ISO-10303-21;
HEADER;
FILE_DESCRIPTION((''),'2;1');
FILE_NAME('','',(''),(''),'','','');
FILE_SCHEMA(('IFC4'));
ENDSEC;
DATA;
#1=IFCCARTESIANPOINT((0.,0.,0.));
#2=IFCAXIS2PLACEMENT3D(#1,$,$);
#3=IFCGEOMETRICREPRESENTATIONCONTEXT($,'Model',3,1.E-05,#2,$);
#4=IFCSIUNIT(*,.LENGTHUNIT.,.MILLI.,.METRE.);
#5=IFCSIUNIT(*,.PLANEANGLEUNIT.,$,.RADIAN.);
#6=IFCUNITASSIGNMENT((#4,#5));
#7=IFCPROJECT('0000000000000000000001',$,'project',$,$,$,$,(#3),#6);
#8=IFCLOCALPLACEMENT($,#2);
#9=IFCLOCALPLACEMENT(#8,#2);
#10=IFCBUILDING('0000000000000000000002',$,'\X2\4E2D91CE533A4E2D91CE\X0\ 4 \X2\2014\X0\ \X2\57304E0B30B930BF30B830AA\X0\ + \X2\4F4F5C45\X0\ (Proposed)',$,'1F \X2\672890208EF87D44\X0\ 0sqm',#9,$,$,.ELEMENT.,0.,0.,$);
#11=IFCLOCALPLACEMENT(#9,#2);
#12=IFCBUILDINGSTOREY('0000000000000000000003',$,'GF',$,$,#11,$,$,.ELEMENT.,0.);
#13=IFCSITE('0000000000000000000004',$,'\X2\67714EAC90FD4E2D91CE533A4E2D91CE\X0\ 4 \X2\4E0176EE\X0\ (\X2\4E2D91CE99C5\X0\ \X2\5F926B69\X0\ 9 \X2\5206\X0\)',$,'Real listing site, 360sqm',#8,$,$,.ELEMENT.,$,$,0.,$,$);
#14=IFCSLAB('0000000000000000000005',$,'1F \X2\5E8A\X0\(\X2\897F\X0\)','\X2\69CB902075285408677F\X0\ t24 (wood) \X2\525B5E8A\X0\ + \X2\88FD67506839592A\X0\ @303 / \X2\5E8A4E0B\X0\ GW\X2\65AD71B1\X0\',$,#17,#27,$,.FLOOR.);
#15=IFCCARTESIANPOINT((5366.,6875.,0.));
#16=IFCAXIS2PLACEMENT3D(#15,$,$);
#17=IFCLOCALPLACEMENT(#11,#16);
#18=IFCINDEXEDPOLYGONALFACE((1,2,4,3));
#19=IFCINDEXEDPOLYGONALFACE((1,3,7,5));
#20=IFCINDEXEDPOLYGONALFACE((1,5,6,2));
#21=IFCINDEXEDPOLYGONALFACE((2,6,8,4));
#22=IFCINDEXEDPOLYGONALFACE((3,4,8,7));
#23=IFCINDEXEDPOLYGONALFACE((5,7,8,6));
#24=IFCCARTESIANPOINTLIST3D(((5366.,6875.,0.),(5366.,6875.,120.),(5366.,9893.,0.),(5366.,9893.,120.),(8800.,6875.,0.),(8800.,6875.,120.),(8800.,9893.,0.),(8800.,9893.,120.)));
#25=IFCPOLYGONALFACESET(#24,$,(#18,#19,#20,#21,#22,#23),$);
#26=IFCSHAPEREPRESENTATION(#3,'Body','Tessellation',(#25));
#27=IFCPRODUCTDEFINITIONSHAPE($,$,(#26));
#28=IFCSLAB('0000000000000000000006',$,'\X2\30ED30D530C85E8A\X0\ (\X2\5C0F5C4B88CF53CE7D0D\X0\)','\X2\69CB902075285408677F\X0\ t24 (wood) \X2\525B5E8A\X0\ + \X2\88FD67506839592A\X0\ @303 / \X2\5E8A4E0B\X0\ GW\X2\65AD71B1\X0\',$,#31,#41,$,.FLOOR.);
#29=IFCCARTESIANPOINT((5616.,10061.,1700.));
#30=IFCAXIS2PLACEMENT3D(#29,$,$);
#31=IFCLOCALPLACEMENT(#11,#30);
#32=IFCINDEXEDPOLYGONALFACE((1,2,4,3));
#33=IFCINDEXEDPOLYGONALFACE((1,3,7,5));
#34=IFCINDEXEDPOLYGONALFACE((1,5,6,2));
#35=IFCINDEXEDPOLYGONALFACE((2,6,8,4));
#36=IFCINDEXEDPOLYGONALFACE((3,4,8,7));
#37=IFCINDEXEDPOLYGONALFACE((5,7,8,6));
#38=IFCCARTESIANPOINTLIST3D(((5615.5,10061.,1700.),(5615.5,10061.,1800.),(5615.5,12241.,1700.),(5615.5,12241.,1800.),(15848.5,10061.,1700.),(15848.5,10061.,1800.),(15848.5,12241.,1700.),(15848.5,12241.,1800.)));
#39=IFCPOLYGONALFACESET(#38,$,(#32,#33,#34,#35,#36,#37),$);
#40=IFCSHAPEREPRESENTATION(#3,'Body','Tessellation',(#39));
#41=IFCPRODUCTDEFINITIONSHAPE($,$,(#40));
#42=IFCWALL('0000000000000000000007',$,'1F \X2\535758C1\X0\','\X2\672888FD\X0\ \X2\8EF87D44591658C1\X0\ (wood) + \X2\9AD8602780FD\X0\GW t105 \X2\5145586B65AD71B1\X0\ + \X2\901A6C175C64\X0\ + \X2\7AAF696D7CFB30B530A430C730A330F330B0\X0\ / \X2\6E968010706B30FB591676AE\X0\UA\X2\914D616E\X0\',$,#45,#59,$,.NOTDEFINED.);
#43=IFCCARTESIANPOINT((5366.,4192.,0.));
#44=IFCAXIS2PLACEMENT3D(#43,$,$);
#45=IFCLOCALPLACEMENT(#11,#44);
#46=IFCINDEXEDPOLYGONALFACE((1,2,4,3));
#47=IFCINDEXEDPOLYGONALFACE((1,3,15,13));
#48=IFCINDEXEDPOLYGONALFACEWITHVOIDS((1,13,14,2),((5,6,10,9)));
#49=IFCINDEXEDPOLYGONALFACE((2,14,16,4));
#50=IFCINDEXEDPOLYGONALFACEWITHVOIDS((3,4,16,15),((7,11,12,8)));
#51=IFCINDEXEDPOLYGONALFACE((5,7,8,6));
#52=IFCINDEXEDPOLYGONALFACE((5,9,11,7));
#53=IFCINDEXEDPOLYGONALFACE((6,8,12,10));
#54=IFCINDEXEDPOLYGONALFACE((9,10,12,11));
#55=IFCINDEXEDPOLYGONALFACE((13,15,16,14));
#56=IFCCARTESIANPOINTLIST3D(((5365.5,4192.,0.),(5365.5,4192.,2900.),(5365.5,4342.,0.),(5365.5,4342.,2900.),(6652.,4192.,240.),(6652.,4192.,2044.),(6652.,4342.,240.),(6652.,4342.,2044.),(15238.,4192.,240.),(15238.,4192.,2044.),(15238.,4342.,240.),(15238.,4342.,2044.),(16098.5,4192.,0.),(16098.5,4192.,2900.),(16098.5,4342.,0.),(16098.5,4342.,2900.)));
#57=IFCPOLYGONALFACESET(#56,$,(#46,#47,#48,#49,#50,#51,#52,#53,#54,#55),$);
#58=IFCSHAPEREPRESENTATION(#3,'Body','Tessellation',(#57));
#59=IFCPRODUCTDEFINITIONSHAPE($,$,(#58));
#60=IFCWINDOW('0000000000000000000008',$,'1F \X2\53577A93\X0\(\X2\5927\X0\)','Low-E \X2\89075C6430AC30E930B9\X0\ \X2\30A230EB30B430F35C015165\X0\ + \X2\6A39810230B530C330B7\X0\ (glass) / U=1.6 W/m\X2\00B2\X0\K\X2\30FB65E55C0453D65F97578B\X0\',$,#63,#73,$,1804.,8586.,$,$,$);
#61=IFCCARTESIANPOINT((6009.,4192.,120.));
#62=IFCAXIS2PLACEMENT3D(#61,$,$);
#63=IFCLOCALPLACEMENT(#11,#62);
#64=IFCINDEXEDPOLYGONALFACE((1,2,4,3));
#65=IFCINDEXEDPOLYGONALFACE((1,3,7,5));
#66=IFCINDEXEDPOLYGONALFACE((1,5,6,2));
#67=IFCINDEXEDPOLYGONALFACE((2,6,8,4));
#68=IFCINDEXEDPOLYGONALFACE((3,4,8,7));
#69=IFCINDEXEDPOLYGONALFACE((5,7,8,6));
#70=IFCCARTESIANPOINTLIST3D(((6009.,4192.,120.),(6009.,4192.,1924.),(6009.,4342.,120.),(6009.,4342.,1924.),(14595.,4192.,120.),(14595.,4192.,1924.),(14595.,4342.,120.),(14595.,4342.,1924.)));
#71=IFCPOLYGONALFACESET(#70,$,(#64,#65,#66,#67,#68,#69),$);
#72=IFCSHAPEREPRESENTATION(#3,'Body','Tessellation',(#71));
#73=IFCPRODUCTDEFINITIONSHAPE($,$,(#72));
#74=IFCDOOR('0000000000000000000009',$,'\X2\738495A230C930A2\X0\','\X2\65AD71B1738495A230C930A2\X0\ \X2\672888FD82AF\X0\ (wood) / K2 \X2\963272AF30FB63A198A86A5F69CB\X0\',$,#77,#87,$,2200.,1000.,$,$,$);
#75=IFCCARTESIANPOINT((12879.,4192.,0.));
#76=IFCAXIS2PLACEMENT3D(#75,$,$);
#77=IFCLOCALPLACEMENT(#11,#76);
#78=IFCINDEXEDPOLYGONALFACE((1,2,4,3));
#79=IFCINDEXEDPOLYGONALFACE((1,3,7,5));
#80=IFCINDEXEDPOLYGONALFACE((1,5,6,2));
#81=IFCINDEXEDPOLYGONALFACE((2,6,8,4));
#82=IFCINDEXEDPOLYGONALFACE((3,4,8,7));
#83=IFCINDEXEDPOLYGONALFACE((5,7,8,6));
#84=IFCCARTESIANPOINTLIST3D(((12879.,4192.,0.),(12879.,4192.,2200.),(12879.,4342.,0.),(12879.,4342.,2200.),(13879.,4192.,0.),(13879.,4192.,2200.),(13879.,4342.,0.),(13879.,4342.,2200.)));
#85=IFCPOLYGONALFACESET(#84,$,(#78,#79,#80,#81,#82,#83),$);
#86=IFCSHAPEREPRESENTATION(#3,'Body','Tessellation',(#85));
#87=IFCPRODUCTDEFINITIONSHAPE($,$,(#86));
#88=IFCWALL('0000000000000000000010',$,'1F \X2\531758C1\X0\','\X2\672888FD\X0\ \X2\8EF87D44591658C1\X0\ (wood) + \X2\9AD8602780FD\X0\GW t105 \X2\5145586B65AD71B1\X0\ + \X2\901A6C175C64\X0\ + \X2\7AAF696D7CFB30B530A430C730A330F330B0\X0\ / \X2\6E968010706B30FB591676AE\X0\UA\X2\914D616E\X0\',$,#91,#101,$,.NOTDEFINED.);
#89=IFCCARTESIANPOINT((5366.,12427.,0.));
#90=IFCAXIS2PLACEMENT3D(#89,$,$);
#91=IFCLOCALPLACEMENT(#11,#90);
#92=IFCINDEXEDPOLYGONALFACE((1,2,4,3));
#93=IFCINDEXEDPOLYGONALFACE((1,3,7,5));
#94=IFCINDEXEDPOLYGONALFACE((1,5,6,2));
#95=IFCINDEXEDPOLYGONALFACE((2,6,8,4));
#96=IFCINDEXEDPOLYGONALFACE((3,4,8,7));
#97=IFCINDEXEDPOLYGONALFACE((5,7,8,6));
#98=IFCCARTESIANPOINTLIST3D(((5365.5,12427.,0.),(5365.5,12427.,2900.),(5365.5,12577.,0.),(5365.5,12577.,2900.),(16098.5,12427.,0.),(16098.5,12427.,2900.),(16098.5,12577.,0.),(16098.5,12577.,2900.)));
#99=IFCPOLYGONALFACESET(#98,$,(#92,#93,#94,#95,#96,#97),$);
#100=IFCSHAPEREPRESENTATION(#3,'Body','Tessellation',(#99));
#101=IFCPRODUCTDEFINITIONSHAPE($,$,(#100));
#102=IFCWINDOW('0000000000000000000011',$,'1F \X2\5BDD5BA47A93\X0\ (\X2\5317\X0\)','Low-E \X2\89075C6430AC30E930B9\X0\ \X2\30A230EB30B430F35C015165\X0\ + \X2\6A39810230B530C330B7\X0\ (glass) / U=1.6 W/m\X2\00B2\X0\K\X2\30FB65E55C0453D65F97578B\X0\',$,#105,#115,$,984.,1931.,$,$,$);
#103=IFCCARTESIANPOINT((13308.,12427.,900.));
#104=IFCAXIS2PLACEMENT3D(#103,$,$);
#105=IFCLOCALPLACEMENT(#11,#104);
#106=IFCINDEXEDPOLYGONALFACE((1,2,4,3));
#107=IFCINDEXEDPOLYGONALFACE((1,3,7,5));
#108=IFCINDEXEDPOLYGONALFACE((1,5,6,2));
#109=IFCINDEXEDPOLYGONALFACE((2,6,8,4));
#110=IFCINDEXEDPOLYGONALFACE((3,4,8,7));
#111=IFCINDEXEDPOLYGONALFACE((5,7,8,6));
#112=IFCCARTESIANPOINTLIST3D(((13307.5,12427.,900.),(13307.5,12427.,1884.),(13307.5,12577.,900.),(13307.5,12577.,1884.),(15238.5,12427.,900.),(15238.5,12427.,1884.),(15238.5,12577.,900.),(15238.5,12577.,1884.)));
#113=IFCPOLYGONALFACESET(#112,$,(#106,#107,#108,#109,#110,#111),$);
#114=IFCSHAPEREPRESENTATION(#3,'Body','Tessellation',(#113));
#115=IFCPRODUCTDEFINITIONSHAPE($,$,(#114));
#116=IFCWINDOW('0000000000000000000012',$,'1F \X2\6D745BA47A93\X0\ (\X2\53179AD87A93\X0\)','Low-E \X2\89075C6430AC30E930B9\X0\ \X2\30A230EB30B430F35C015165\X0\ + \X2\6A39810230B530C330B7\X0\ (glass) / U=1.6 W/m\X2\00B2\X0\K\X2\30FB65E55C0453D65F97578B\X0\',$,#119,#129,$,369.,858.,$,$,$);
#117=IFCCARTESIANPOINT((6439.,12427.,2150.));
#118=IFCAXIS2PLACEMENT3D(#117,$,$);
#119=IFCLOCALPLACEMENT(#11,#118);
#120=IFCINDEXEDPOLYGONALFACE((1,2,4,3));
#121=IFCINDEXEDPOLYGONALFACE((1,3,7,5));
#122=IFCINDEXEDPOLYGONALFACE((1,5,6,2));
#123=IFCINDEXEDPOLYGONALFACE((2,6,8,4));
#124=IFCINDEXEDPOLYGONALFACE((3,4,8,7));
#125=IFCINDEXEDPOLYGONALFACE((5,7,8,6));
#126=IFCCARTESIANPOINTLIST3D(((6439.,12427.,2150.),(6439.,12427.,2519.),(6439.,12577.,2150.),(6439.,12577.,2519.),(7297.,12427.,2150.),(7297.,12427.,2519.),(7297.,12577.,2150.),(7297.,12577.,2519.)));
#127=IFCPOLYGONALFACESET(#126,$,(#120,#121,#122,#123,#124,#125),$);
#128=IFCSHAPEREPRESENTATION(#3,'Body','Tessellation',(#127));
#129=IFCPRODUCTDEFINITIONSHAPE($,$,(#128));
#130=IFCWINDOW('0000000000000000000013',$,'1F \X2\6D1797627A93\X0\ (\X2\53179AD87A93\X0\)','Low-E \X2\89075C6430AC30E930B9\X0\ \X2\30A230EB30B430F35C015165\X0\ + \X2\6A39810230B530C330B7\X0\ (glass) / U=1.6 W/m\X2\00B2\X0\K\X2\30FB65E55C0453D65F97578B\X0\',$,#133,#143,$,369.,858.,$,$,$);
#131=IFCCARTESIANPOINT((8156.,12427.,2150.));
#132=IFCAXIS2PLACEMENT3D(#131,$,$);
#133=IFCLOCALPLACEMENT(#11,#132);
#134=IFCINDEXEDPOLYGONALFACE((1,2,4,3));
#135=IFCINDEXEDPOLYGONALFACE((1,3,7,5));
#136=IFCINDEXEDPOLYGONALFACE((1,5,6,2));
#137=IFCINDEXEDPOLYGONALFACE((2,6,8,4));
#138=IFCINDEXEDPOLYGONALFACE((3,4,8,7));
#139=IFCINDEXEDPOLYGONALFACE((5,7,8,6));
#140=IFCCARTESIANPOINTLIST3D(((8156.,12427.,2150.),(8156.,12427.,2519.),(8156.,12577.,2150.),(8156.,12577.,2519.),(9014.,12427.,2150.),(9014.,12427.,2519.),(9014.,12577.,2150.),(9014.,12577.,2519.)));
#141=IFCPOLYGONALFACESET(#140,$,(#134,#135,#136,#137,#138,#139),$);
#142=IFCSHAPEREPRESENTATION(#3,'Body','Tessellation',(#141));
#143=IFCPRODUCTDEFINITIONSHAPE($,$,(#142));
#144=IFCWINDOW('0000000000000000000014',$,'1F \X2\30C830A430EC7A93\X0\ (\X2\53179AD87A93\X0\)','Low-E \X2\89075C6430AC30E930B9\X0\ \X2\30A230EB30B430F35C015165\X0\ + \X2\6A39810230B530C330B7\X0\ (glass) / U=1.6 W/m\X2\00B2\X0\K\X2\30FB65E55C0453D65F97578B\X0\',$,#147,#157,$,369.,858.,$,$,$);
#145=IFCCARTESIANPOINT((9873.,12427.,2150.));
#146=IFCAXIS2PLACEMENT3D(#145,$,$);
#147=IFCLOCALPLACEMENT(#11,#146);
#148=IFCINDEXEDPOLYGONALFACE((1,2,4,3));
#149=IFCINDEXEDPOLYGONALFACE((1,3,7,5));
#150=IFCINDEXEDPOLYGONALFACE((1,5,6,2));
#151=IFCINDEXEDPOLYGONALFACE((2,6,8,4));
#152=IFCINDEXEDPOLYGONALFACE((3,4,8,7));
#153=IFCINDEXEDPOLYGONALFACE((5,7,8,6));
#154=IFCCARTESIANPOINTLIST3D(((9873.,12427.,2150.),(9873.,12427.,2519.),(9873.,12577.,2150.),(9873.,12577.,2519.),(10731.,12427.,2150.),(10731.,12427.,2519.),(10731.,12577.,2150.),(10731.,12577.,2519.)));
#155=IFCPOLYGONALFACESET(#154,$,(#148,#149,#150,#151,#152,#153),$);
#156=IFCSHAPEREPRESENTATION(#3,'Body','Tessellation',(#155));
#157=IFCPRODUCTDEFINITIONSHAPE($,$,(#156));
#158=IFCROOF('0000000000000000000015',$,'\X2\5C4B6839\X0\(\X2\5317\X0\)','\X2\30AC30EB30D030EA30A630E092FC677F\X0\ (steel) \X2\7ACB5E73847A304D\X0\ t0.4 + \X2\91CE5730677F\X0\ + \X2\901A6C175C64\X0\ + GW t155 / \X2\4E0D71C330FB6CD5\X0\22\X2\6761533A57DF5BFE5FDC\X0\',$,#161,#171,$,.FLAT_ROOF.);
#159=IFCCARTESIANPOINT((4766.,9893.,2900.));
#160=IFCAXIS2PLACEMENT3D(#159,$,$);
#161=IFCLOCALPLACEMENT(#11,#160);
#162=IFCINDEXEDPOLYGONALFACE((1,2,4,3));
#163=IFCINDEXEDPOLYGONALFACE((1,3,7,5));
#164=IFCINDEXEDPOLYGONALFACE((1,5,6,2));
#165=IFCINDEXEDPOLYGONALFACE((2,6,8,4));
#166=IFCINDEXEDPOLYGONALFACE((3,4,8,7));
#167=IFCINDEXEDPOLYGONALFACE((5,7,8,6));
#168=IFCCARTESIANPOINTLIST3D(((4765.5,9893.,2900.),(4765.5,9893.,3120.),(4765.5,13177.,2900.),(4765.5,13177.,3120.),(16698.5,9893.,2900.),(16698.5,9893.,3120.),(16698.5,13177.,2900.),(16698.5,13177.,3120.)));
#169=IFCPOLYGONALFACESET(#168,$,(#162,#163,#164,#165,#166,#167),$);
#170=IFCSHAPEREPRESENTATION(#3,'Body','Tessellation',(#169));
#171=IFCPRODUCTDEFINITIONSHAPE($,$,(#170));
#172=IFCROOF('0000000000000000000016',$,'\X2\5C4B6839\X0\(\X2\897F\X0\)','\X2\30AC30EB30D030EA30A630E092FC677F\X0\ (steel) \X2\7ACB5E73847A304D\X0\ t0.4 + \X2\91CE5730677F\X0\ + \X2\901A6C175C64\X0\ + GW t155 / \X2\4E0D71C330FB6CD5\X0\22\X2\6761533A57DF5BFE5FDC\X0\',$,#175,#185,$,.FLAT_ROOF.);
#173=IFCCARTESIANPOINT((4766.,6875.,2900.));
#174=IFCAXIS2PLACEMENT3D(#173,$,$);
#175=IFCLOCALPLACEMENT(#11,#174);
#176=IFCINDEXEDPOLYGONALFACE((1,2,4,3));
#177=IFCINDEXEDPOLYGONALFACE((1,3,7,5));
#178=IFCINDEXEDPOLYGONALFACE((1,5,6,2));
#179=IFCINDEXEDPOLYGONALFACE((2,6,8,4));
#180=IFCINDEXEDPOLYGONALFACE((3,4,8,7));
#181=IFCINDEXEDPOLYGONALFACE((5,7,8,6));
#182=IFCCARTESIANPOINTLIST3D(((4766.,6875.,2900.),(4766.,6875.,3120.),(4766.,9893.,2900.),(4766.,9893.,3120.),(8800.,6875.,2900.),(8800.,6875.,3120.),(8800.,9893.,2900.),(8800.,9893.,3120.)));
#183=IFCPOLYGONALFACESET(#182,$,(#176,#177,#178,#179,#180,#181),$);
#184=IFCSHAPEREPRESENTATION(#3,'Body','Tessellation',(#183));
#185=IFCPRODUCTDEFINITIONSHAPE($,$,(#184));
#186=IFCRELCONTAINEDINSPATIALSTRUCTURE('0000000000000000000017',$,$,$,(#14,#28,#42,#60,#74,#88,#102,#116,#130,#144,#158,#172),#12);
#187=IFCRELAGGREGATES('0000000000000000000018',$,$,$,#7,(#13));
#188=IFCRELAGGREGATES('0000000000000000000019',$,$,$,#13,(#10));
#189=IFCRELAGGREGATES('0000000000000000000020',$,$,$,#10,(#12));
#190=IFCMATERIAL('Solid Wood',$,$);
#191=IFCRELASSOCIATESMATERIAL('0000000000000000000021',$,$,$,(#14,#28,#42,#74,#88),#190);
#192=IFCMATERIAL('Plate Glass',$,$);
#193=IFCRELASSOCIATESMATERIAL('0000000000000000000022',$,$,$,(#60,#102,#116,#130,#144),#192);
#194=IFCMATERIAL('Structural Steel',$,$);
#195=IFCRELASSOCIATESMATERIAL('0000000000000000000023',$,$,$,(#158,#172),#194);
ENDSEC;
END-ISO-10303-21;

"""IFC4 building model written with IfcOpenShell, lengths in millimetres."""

from ifc_helpers import new_model, si_unit, frame, frame_2d, origin, place, context, project, spatial, rectangle, extrude, material, element, fill, save


model = new_model("IFC4")

# Units and contexts
model_context = context("Model", 3, precision=1e-05, world=origin())
ifc_project = project(units=[si_unit("LENGTHUNIT", "METRE", prefix="MILLI"), si_unit("PLANEANGLEUNIT", "RADIAN")], contexts=[model_context])

# Site, building, storey
site_placement = place(None, origin())
site = spatial("IfcSite", under=ifc_project, at=site_placement, Name="東京都中野区中野 4 丁目 (中野駅 徒歩 9 分)", ObjectType="Real listing site, 360sqm", CompositionType="ELEMENT", RefElevation=0.0)
building_placement = place(site_placement, origin())
building = spatial("IfcBuilding", under=site, at=building_placement, Name="中野区中野 4 — 地下スタジオ + 住居 (Proposed)", ObjectType="1F 木造軸組 0sqm", CompositionType="ELEMENT", ElevationOfRefHeight=0.0, ElevationOfTerrain=0.0)
storey_placement = place(building_placement, origin())
storey = spatial("IfcBuildingStorey", under=building, at=storey_placement, Name="GF", CompositionType="ELEMENT", Elevation=0.0)

# Slabs
ifc_material_1 = material(Name="Solid Wood")
slab_1_placement = place(storey_placement, frame((5366.0, 6875.0, 0.0)))
element("IfcSlab", 1, at=slab_1_placement, inside=storey, material=ifc_material_1, Name="1F 床(西)", Description="構造用合板 t24 (wood) 剛床 + 製材根太 @303 / 床下 GW断熱", PredefinedType="FLOOR", context=model_context, shape_type="SweptSolid", body=[
    extrude(rectangle(XDim=3434.0, YDim=3018.0, at=frame_2d((1717.0, 1509.0))), frame((5366.0, 6875.0, 0.0)), (0.0, 0.0, 1.0), 120.0),
])
slab_2_placement = place(storey_placement, frame((5616.0, 10061.0, 1700.0)))
element("IfcSlab", 2, at=slab_2_placement, inside=storey, material=ifc_material_1, Name="ロフト床 (小屋裏収納)", Description="構造用合板 t24 (wood) 剛床 + 製材根太 @303 / 床下 GW断熱", PredefinedType="FLOOR", context=model_context, shape_type="SweptSolid", body=[
    extrude(rectangle(XDim=10233.0, YDim=2180.0, at=frame_2d((5116.0, 1090.0))), frame((5616.0, 10061.0, 1700.0)), (0.0, 0.0, 1.0), 100.0),
])

# Wall, openings, window, door
wall_1_placement = place(storey_placement, frame((5366.0, 4192.0, 0.0)))
wall_1 = element("IfcWall", 3, at=wall_1_placement, inside=storey, material=ifc_material_1, Name="1F 南壁", Description="木製 軸組外壁 (wood) + 高性能GW t105 充填断熱 + 通気層 + 窯業系サイディング / 準耐火・外皮UA配慮", PredefinedType="NOTDEFINED", context=model_context, shape_type="SweptSolid", body=[
    extrude(rectangle(XDim=10733.0, YDim=150.0, at=frame_2d((5366.0, 75.0))), frame((5366.0, 4192.0, 0.0)), (0.0, 0.0, 1.0), 2900.0),
])
opening_1_placement = place(storey_placement, frame((6009.0, 4192.0, 120.0)))
opening_1 = element("IfcOpeningElement", 4, at=opening_1_placement, cuts=wall_1, PredefinedType="NOTDEFINED", context=model_context, shape_type="SweptSolid", body=[
    extrude(rectangle(XDim=8586.0, YDim=150.0, at=frame_2d((4293.0, 75.0))), frame((6009.0, 4192.0, 120.0)), (0.0, 0.0, 1.0), 1804.0),
])
opening_2_placement = place(storey_placement, frame((12879.0, 4192.0, 0.0)))
opening_2 = element("IfcOpeningElement", 5, at=opening_2_placement, cuts=wall_1, PredefinedType="NOTDEFINED", context=model_context, shape_type="SweptSolid", body=[
    extrude(rectangle(XDim=1000.0, YDim=150.0, at=frame_2d((500.0, 75.0))), frame((12879.0, 4192.0, 0.0)), (0.0, 0.0, 1.0), 2200.0),
])
ifc_material_2 = material(Name="Plate Glass")
window_1_placement = place(storey_placement, frame((6009.0, 4192.0, 120.0)))
window_1 = element("IfcWindow", 6, at=window_1_placement, inside=storey, material=ifc_material_2, Name="1F 南窓(大)", Description="Low-E 複層ガラス アルゴン封入 + 樹脂サッシ (glass) / U=1.6 W/m²K・日射取得型", OverallHeight=1804.0, OverallWidth=8586.0, context=model_context, shape_type="SweptSolid", body=[
    extrude(rectangle(XDim=8586.0, YDim=150.0, at=frame_2d((4293.0, 75.0))), frame((6009.0, 4192.0, 120.0)), (0.0, 0.0, 1.0), 1804.0),
])
fill(opening_1, window_1)
door_1_placement = place(storey_placement, frame((12879.0, 4192.0, 0.0)))
door_1 = element("IfcDoor", 7, at=door_1_placement, inside=storey, material=ifc_material_1, Name="玄関ドア", Description="断熱玄関ドア 木製芯 (wood) / K2 防犯・採風機構", OverallHeight=2200.0, OverallWidth=1000.0, context=model_context, shape_type="SweptSolid", body=[
    extrude(rectangle(XDim=1000.0, YDim=150.0, at=frame_2d((500.0, 75.0))), frame((12879.0, 4192.0, 0.0)), (0.0, 0.0, 1.0), 2200.0),
])
fill(opening_2, door_1)

# Wall, openings, windows
wall_2_placement = place(storey_placement, frame((5366.0, 12427.0, 0.0)))
wall_2 = element("IfcWall", 8, at=wall_2_placement, inside=storey, material=ifc_material_1, Name="1F 北壁", Description="木製 軸組外壁 (wood) + 高性能GW t105 充填断熱 + 通気層 + 窯業系サイディング / 準耐火・外皮UA配慮", PredefinedType="NOTDEFINED", context=model_context, shape_type="SweptSolid", body=[
    extrude(rectangle(XDim=10733.0, YDim=150.0, at=frame_2d((5366.0, 75.0))), frame((5366.0, 12427.0, 0.0)), (0.0, 0.0, 1.0), 2900.0),
])
opening_3_placement = place(storey_placement, frame((13308.0, 12427.0, 900.0)))
opening_3 = element("IfcOpeningElement", 9, at=opening_3_placement, cuts=wall_2, PredefinedType="NOTDEFINED", context=model_context, shape_type="SweptSolid", body=[
    extrude(rectangle(XDim=1931.0, YDim=150.0, at=frame_2d((965.0, 75.0))), frame((13308.0, 12427.0, 900.0)), (0.0, 0.0, 1.0), 984.0),
])
opening_4_placement = place(storey_placement, frame((6439.0, 12427.0, 2150.0)))
opening_4 = element("IfcOpeningElement", 10, at=opening_4_placement, cuts=wall_2, PredefinedType="NOTDEFINED", context=model_context, shape_type="SweptSolid", body=[
    extrude(rectangle(XDim=858.0, YDim=150.0, at=frame_2d((429.0, 75.0))), frame((6439.0, 12427.0, 2150.0)), (0.0, 0.0, 1.0), 369.0),
])
opening_5_placement = place(storey_placement, frame((8156.0, 12427.0, 2150.0)))
opening_5 = element("IfcOpeningElement", 11, at=opening_5_placement, cuts=wall_2, PredefinedType="NOTDEFINED", context=model_context, shape_type="SweptSolid", body=[
    extrude(rectangle(XDim=858.0, YDim=150.0, at=frame_2d((429.0, 75.0))), frame((8156.0, 12427.0, 2150.0)), (0.0, 0.0, 1.0), 369.0),
])
opening_6_placement = place(storey_placement, frame((9873.0, 12427.0, 2150.0)))
opening_6 = element("IfcOpeningElement", 12, at=opening_6_placement, cuts=wall_2, PredefinedType="NOTDEFINED", context=model_context, shape_type="SweptSolid", body=[
    extrude(rectangle(XDim=858.0, YDim=150.0, at=frame_2d((429.0, 75.0))), frame((9873.0, 12427.0, 2150.0)), (0.0, 0.0, 1.0), 369.0),
])
window_2_placement = place(storey_placement, frame((13308.0, 12427.0, 900.0)))
window_2 = element("IfcWindow", 13, at=window_2_placement, inside=storey, material=ifc_material_2, Name="1F 寝室窓 (北)", Description="Low-E 複層ガラス アルゴン封入 + 樹脂サッシ (glass) / U=1.6 W/m²K・日射取得型", OverallHeight=984.0, OverallWidth=1931.0, context=model_context, shape_type="SweptSolid", body=[
    extrude(rectangle(XDim=1931.0, YDim=150.0, at=frame_2d((965.0, 75.0))), frame((13308.0, 12427.0, 900.0)), (0.0, 0.0, 1.0), 984.0),
])
fill(opening_3, window_2)
window_3_placement = place(storey_placement, frame((6439.0, 12427.0, 2150.0)))
window_3 = element("IfcWindow", 14, at=window_3_placement, inside=storey, material=ifc_material_2, Name="1F 浴室窓 (北高窓)", Description="Low-E 複層ガラス アルゴン封入 + 樹脂サッシ (glass) / U=1.6 W/m²K・日射取得型", OverallHeight=369.0, OverallWidth=858.0, context=model_context, shape_type="SweptSolid", body=[
    extrude(rectangle(XDim=858.0, YDim=150.0, at=frame_2d((429.0, 75.0))), frame((6439.0, 12427.0, 2150.0)), (0.0, 0.0, 1.0), 369.0),
])
fill(opening_4, window_3)
window_4_placement = place(storey_placement, frame((8156.0, 12427.0, 2150.0)))
window_4 = element("IfcWindow", 15, at=window_4_placement, inside=storey, material=ifc_material_2, Name="1F 洗面窓 (北高窓)", Description="Low-E 複層ガラス アルゴン封入 + 樹脂サッシ (glass) / U=1.6 W/m²K・日射取得型", OverallHeight=369.0, OverallWidth=858.0, context=model_context, shape_type="SweptSolid", body=[
    extrude(rectangle(XDim=858.0, YDim=150.0, at=frame_2d((429.0, 75.0))), frame((8156.0, 12427.0, 2150.0)), (0.0, 0.0, 1.0), 369.0),
])
fill(opening_5, window_4)
window_5_placement = place(storey_placement, frame((9873.0, 12427.0, 2150.0)))
window_5 = element("IfcWindow", 16, at=window_5_placement, inside=storey, material=ifc_material_2, Name="1F トイレ窓 (北高窓)", Description="Low-E 複層ガラス アルゴン封入 + 樹脂サッシ (glass) / U=1.6 W/m²K・日射取得型", OverallHeight=369.0, OverallWidth=858.0, context=model_context, shape_type="SweptSolid", body=[
    extrude(rectangle(XDim=858.0, YDim=150.0, at=frame_2d((429.0, 75.0))), frame((9873.0, 12427.0, 2150.0)), (0.0, 0.0, 1.0), 369.0),
])
fill(opening_6, window_5)

# Roofs
ifc_material_3 = material(Name="Structural Steel")
roof_1_placement = place(storey_placement, frame((4766.0, 9893.0, 2900.0)))
element("IfcRoof", 17, at=roof_1_placement, inside=storey, material=ifc_material_3, Name="屋根(北)", Description="ガルバリウム鋼板 (steel) 立平葺き t0.4 + 野地板 + 通気層 + GW t155 / 不燃・法22条区域対応", PredefinedType="FLAT_ROOF", context=model_context, shape_type="SweptSolid", body=[
    extrude(rectangle(XDim=11933.0, YDim=3284.0, at=frame_2d((5966.0, 1642.0))), frame((4766.0, 9893.0, 2900.0)), (0.0, 0.0, 1.0), 220.0),
])
roof_2_placement = place(storey_placement, frame((4766.0, 6875.0, 2900.0)))
element("IfcRoof", 18, at=roof_2_placement, inside=storey, material=ifc_material_3, Name="屋根(西)", Description="ガルバリウム鋼板 (steel) 立平葺き t0.4 + 野地板 + 通気層 + GW t155 / 不燃・法22条区域対応", PredefinedType="FLAT_ROOF", context=model_context, shape_type="SweptSolid", body=[
    extrude(rectangle(XDim=4034.0, YDim=3018.0, at=frame_2d((2017.0, 1509.0))), frame((4766.0, 6875.0, 2900.0)), (0.0, 0.0, 1.0), 220.0),
])

save(model, "model.ifc")
